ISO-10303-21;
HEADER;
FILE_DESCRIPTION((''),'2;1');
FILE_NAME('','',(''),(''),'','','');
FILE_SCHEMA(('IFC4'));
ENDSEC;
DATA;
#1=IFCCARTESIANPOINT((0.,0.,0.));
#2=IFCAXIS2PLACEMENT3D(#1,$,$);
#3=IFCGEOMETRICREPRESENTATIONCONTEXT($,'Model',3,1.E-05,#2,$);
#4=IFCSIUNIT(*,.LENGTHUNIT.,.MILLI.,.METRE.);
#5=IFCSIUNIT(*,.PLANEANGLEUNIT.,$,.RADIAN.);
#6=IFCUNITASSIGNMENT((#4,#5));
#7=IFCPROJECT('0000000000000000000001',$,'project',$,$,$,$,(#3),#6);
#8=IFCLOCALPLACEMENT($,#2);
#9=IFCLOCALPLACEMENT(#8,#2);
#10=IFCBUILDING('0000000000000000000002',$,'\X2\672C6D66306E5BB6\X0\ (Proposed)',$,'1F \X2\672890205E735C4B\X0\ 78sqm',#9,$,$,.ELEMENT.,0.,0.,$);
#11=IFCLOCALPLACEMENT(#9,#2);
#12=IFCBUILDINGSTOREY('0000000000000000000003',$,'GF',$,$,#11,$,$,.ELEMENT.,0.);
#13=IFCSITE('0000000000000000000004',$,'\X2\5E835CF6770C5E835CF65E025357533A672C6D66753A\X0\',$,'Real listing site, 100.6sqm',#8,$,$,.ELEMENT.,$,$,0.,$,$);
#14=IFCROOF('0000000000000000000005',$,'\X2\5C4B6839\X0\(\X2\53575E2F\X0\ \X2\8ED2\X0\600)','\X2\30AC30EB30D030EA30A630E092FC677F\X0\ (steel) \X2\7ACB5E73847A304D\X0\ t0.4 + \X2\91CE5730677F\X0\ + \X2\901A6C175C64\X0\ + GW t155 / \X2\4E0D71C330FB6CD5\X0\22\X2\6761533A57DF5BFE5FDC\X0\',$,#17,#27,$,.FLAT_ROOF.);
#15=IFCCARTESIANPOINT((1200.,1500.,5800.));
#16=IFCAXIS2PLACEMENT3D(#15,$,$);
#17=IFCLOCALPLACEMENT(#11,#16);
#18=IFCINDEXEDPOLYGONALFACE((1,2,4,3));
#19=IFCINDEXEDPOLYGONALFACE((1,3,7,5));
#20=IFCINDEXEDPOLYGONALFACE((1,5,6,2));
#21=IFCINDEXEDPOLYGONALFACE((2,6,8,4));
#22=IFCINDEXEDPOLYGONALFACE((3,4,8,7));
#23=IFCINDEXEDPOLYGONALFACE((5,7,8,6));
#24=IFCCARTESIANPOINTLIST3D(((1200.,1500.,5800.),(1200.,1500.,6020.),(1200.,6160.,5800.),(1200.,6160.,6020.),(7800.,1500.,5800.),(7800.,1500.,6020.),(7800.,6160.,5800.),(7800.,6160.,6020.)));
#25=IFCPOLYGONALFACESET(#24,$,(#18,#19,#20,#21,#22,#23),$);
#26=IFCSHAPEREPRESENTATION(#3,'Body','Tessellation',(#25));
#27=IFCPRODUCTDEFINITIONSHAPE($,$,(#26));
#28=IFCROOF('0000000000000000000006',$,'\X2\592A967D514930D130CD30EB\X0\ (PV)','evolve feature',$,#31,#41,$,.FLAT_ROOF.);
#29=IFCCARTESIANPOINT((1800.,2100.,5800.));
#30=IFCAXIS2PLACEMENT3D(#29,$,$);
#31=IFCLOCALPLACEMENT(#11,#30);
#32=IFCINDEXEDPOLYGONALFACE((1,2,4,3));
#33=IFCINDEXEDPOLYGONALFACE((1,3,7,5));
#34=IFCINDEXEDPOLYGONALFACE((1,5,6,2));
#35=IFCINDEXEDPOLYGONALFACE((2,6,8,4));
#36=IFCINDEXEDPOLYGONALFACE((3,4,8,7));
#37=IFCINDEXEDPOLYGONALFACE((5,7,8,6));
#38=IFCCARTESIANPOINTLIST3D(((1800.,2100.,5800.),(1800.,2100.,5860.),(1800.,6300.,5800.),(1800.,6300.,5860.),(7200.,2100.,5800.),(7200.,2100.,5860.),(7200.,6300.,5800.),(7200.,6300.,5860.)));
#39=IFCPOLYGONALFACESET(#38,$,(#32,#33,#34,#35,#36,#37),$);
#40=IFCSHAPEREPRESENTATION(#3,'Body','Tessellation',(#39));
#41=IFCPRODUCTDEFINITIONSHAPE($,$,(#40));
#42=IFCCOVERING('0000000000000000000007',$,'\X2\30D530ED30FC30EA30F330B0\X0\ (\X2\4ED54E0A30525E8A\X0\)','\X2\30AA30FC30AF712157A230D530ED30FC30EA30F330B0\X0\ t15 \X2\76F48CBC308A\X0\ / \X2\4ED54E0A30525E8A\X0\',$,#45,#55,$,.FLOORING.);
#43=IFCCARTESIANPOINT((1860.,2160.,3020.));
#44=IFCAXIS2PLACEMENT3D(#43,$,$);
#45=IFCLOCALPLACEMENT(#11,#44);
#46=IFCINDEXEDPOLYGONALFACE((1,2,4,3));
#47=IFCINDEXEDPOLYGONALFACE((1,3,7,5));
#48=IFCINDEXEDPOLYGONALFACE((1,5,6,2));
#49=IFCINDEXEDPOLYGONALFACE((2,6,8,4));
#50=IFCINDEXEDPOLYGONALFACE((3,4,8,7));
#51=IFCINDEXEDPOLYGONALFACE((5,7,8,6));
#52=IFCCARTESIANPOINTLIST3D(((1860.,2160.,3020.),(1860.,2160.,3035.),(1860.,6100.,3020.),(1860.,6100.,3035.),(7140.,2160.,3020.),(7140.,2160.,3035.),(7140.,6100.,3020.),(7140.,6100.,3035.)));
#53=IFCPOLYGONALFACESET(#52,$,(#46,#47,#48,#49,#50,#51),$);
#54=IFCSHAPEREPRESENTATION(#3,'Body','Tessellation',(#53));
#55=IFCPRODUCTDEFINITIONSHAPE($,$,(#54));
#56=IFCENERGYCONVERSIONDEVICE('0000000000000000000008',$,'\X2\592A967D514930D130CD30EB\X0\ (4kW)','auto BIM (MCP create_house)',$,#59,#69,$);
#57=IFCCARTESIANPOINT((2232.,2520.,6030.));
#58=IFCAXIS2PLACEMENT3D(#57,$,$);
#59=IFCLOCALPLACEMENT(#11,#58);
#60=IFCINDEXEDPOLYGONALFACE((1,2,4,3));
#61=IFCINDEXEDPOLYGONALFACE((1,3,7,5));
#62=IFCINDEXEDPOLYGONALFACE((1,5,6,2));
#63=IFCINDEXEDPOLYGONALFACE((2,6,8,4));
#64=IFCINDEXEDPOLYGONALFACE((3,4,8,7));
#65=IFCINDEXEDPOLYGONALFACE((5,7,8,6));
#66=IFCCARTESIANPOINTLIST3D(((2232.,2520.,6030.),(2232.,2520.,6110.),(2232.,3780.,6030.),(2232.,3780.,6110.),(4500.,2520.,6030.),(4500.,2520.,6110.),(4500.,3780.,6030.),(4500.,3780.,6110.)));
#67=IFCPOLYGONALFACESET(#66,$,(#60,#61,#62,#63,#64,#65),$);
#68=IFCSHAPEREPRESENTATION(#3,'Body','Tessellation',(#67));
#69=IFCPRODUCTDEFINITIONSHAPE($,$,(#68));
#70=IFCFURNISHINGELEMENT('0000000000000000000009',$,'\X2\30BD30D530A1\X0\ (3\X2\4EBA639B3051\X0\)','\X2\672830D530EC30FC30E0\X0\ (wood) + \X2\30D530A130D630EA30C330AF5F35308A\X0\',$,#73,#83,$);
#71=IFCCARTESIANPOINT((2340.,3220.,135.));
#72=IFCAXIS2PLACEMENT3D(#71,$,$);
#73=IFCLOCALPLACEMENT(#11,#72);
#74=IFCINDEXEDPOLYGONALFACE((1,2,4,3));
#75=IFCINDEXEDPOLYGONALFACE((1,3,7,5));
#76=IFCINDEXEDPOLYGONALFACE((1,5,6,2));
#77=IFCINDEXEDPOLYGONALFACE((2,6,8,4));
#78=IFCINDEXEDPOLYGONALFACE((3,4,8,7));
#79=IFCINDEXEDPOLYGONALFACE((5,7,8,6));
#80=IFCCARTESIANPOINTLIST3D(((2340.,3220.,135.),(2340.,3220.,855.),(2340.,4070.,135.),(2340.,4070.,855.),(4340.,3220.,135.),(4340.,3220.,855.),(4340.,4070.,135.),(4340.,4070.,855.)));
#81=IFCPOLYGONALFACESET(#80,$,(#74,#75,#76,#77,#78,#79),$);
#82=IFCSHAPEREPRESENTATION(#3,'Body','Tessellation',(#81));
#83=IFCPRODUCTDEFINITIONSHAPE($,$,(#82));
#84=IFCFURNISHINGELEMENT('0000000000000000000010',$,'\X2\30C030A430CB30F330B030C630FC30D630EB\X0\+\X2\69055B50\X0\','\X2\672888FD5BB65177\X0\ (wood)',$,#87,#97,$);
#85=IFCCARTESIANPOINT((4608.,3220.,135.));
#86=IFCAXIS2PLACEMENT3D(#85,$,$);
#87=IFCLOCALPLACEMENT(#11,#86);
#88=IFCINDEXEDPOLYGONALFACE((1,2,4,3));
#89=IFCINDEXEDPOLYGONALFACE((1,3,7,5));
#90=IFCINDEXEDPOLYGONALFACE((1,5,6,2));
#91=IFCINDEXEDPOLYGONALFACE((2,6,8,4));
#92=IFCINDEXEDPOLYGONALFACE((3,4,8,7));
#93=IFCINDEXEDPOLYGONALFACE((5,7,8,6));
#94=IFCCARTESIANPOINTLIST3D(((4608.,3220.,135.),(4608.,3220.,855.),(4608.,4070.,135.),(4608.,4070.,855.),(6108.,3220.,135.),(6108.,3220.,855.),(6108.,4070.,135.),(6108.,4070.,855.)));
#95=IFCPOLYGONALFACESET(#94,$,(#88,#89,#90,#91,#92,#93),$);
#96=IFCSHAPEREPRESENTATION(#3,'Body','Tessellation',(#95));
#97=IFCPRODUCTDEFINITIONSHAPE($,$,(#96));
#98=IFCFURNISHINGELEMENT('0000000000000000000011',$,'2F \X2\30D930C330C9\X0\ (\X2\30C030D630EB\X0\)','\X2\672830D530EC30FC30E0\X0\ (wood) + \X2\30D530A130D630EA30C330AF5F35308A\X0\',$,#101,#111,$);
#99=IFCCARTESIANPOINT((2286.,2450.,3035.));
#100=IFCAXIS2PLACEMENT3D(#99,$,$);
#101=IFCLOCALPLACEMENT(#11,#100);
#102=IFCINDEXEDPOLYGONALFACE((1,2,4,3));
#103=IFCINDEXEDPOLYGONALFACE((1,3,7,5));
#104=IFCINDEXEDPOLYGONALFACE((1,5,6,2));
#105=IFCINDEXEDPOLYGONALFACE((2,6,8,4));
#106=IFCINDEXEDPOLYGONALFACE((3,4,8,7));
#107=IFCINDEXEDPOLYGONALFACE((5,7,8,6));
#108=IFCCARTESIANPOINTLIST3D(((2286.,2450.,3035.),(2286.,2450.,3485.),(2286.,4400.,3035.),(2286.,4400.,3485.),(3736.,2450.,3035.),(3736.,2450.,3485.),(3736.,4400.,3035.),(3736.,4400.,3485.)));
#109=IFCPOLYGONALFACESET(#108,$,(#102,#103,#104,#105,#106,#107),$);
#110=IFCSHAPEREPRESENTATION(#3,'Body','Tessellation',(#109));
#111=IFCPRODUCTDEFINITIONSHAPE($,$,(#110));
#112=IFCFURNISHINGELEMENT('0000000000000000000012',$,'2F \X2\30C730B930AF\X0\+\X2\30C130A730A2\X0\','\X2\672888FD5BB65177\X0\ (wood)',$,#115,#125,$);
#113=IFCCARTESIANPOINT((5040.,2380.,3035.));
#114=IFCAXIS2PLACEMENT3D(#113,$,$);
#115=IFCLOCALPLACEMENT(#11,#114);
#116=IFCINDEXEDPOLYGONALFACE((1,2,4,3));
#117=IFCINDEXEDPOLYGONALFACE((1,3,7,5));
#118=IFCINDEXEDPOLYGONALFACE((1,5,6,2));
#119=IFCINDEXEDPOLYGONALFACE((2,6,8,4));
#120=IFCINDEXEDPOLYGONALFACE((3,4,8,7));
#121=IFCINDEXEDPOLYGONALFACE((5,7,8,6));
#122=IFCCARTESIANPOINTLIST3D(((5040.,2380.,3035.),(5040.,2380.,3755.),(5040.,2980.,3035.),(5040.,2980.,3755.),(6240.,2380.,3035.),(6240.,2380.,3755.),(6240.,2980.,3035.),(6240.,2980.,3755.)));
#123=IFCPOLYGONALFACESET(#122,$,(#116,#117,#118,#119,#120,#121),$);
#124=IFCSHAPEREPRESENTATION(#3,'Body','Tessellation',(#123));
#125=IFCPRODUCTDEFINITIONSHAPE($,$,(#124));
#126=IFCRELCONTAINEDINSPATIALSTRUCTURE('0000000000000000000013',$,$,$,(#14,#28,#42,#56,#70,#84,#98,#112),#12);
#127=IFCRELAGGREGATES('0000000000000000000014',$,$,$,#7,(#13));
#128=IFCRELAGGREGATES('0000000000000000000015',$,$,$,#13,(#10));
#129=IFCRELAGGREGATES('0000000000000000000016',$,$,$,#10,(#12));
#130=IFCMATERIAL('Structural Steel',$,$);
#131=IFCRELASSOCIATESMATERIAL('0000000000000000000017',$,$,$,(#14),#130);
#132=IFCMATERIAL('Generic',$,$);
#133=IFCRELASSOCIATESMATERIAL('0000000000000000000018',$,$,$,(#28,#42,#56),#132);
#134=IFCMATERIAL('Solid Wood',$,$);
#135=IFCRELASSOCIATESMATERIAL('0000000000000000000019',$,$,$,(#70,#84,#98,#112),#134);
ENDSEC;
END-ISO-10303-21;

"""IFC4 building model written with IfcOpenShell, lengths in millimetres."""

from ifc_helpers import new_model, si_unit, frame, frame_2d, origin, place, context, project, spatial, rectangle, extrude, material, element, save


model = new_model("IFC4")

# Units and contexts
model_context = context("Model", 3, precision=1e-05, world=origin())
ifc_project = project(units=[si_unit("LENGTHUNIT", "METRE", prefix="MILLI"), si_unit("PLANEANGLEUNIT", "RADIAN")], contexts=[model_context])

# Site, building, storey
site_placement = place(None, origin())
site = spatial("IfcSite", under=ifc_project, at=site_placement, Name="広島県広島市南区本浦町", ObjectType="Real listing site, 100.6sqm", CompositionType="ELEMENT", RefElevation=0.0)
building_placement = place(site_placement, origin())
building = spatial("IfcBuilding", under=site, at=building_placement, Name="本浦の家 (Proposed)", ObjectType="1F 木造平屋 78sqm", CompositionType="ELEMENT", ElevationOfRefHeight=0.0, ElevationOfTerrain=0.0)
storey_placement = place(building_placement, origin())
storey = spatial("IfcBuildingStorey", under=building, at=storey_placement, Name="GF", CompositionType="ELEMENT", Elevation=0.0)

# Shared definitions
ifc_material_1 = material(Name="Solid Wood")

# Shared definitions
ifc_material_2 = material(Name="Generic")

# Roofs
ifc_material_3 = material(Name="Structural Steel")
for number, where, name in (
    (1, (1200.0, 1500.0, 5800.0), "屋根(南帯 軒600)"),
):
    element("IfcRoof", number, at=place(storey_placement, frame(where)), inside=storey, material=ifc_material_3, Name=name, Description="ガルバリウム鋼板 (steel) 立平葺き t0.4 + 野地板 + 通気層 + GW t155 / 不燃・法22条区域対応", PredefinedType="FLAT_ROOF", context=model_context, shape_type="SweptSolid", body=[
        extrude(rectangle(XDim=6600.0, YDim=4660.0, at=frame_2d((3300.0, 2330.0))), frame((1200.0, 1500.0, 5800.0)), (0.0, 0.0, 1.0), 220.0),
    ])
roof_placement = place(storey_placement, frame((1800.0, 2100.0, 5800.0)))
element("IfcRoof", 2, at=roof_placement, inside=storey, material=ifc_material_2, Name="太陽光パネル (PV)", Description="evolve feature", PredefinedType="FLAT_ROOF", context=model_context, shape_type="SweptSolid", body=[
    extrude(rectangle(XDim=5400.0, YDim=4200.0, at=frame_2d((2700.0, 2100.0))), frame((1800.0, 2100.0, 5800.0)), (0.0, 0.0, 1.0), 60.0),
])

# Covering
covering_placement = place(storey_placement, frame((1860.0, 2160.0, 3020.0)))
element("IfcCovering", 3, at=covering_placement, inside=storey, material=ifc_material_2, Name="フローリング (仕上げ床)", Description="オーク無垢フローリング t15 直貼り / 仕上げ床", PredefinedType="FLOORING", context=model_context, shape_type="SweptSolid", body=[
    extrude(rectangle(XDim=5280.0, YDim=3940.0, at=frame_2d((2640.0, 1970.0))), frame((1860.0, 2160.0, 3020.0)), (0.0, 0.0, 1.0), 15.0),
])

# Energy conversion device
energy_conversion_device_placement = place(storey_placement, frame((2232.0, 2520.0, 6030.0)))
element("IfcEnergyConversionDevice", 4, at=energy_conversion_device_placement, inside=storey, material=ifc_material_2, Name="太陽光パネル (4kW)", Description="auto BIM (MCP create_house)", context=model_context, shape_type="SweptSolid", body=[
    extrude(rectangle(XDim=2268.0, YDim=1260.0, at=frame_2d((1134.0, 630.0))), frame((2232.0, 2520.0, 6030.0)), (0.0, 0.0, 1.0), 80.0),
])

# Furnishing elements
furnishing_1_placement = place(storey_placement, frame((2340.0, 3220.0, 135.0)))
element("IfcFurnishingElement", 5, at=furnishing_1_placement, inside=storey, material=ifc_material_1, Name="ソファ (3人掛け)", Description="木フレーム (wood) + ファブリック張り", context=model_context, shape_type="SweptSolid", body=[
    extrude(rectangle(XDim=2000.0, YDim=850.0, at=frame_2d((1000.0, 425.0))), frame((2340.0, 3220.0, 135.0)), (0.0, 0.0, 1.0), 720.0),
])
furnishing_2_placement = place(storey_placement, frame((4608.0, 3220.0, 135.0)))
element("IfcFurnishingElement", 6, at=furnishing_2_placement, inside=storey, material=ifc_material_1, Name="ダイニングテーブル+椅子", Description="木製家具 (wood)", context=model_context, shape_type="SweptSolid", body=[
    extrude(rectangle(XDim=1500.0, YDim=850.0, at=frame_2d((750.0, 425.0))), frame((4608.0, 3220.0, 135.0)), (0.0, 0.0, 1.0), 720.0),
])
furnishing_3_placement = place(storey_placement, frame((2286.0, 2450.0, 3035.0)))
element("IfcFurnishingElement", 7, at=furnishing_3_placement, inside=storey, material=ifc_material_1, Name="2F ベッド (ダブル)", Description="木フレーム (wood) + ファブリック張り", context=model_context, shape_type="SweptSolid", body=[
    extrude(rectangle(XDim=1450.0, YDim=1950.0, at=frame_2d((725.0, 975.0))), frame((2286.0, 2450.0, 3035.0)), (0.0, 0.0, 1.0), 450.0),
])
furnishing_4_placement = place(storey_placement, frame((5040.0, 2380.0, 3035.0)))
element("IfcFurnishingElement", 8, at=furnishing_4_placement, inside=storey, material=ifc_material_1, Name="2F デスク+チェア", Description="木製家具 (wood)", context=model_context, shape_type="SweptSolid", body=[
    extrude(rectangle(XDim=1200.0, YDim=600.0, at=frame_2d((600.0, 300.0))), frame((5040.0, 2380.0, 3035.0)), (0.0, 0.0, 1.0), 720.0),
])

save(model, "model.ifc")
